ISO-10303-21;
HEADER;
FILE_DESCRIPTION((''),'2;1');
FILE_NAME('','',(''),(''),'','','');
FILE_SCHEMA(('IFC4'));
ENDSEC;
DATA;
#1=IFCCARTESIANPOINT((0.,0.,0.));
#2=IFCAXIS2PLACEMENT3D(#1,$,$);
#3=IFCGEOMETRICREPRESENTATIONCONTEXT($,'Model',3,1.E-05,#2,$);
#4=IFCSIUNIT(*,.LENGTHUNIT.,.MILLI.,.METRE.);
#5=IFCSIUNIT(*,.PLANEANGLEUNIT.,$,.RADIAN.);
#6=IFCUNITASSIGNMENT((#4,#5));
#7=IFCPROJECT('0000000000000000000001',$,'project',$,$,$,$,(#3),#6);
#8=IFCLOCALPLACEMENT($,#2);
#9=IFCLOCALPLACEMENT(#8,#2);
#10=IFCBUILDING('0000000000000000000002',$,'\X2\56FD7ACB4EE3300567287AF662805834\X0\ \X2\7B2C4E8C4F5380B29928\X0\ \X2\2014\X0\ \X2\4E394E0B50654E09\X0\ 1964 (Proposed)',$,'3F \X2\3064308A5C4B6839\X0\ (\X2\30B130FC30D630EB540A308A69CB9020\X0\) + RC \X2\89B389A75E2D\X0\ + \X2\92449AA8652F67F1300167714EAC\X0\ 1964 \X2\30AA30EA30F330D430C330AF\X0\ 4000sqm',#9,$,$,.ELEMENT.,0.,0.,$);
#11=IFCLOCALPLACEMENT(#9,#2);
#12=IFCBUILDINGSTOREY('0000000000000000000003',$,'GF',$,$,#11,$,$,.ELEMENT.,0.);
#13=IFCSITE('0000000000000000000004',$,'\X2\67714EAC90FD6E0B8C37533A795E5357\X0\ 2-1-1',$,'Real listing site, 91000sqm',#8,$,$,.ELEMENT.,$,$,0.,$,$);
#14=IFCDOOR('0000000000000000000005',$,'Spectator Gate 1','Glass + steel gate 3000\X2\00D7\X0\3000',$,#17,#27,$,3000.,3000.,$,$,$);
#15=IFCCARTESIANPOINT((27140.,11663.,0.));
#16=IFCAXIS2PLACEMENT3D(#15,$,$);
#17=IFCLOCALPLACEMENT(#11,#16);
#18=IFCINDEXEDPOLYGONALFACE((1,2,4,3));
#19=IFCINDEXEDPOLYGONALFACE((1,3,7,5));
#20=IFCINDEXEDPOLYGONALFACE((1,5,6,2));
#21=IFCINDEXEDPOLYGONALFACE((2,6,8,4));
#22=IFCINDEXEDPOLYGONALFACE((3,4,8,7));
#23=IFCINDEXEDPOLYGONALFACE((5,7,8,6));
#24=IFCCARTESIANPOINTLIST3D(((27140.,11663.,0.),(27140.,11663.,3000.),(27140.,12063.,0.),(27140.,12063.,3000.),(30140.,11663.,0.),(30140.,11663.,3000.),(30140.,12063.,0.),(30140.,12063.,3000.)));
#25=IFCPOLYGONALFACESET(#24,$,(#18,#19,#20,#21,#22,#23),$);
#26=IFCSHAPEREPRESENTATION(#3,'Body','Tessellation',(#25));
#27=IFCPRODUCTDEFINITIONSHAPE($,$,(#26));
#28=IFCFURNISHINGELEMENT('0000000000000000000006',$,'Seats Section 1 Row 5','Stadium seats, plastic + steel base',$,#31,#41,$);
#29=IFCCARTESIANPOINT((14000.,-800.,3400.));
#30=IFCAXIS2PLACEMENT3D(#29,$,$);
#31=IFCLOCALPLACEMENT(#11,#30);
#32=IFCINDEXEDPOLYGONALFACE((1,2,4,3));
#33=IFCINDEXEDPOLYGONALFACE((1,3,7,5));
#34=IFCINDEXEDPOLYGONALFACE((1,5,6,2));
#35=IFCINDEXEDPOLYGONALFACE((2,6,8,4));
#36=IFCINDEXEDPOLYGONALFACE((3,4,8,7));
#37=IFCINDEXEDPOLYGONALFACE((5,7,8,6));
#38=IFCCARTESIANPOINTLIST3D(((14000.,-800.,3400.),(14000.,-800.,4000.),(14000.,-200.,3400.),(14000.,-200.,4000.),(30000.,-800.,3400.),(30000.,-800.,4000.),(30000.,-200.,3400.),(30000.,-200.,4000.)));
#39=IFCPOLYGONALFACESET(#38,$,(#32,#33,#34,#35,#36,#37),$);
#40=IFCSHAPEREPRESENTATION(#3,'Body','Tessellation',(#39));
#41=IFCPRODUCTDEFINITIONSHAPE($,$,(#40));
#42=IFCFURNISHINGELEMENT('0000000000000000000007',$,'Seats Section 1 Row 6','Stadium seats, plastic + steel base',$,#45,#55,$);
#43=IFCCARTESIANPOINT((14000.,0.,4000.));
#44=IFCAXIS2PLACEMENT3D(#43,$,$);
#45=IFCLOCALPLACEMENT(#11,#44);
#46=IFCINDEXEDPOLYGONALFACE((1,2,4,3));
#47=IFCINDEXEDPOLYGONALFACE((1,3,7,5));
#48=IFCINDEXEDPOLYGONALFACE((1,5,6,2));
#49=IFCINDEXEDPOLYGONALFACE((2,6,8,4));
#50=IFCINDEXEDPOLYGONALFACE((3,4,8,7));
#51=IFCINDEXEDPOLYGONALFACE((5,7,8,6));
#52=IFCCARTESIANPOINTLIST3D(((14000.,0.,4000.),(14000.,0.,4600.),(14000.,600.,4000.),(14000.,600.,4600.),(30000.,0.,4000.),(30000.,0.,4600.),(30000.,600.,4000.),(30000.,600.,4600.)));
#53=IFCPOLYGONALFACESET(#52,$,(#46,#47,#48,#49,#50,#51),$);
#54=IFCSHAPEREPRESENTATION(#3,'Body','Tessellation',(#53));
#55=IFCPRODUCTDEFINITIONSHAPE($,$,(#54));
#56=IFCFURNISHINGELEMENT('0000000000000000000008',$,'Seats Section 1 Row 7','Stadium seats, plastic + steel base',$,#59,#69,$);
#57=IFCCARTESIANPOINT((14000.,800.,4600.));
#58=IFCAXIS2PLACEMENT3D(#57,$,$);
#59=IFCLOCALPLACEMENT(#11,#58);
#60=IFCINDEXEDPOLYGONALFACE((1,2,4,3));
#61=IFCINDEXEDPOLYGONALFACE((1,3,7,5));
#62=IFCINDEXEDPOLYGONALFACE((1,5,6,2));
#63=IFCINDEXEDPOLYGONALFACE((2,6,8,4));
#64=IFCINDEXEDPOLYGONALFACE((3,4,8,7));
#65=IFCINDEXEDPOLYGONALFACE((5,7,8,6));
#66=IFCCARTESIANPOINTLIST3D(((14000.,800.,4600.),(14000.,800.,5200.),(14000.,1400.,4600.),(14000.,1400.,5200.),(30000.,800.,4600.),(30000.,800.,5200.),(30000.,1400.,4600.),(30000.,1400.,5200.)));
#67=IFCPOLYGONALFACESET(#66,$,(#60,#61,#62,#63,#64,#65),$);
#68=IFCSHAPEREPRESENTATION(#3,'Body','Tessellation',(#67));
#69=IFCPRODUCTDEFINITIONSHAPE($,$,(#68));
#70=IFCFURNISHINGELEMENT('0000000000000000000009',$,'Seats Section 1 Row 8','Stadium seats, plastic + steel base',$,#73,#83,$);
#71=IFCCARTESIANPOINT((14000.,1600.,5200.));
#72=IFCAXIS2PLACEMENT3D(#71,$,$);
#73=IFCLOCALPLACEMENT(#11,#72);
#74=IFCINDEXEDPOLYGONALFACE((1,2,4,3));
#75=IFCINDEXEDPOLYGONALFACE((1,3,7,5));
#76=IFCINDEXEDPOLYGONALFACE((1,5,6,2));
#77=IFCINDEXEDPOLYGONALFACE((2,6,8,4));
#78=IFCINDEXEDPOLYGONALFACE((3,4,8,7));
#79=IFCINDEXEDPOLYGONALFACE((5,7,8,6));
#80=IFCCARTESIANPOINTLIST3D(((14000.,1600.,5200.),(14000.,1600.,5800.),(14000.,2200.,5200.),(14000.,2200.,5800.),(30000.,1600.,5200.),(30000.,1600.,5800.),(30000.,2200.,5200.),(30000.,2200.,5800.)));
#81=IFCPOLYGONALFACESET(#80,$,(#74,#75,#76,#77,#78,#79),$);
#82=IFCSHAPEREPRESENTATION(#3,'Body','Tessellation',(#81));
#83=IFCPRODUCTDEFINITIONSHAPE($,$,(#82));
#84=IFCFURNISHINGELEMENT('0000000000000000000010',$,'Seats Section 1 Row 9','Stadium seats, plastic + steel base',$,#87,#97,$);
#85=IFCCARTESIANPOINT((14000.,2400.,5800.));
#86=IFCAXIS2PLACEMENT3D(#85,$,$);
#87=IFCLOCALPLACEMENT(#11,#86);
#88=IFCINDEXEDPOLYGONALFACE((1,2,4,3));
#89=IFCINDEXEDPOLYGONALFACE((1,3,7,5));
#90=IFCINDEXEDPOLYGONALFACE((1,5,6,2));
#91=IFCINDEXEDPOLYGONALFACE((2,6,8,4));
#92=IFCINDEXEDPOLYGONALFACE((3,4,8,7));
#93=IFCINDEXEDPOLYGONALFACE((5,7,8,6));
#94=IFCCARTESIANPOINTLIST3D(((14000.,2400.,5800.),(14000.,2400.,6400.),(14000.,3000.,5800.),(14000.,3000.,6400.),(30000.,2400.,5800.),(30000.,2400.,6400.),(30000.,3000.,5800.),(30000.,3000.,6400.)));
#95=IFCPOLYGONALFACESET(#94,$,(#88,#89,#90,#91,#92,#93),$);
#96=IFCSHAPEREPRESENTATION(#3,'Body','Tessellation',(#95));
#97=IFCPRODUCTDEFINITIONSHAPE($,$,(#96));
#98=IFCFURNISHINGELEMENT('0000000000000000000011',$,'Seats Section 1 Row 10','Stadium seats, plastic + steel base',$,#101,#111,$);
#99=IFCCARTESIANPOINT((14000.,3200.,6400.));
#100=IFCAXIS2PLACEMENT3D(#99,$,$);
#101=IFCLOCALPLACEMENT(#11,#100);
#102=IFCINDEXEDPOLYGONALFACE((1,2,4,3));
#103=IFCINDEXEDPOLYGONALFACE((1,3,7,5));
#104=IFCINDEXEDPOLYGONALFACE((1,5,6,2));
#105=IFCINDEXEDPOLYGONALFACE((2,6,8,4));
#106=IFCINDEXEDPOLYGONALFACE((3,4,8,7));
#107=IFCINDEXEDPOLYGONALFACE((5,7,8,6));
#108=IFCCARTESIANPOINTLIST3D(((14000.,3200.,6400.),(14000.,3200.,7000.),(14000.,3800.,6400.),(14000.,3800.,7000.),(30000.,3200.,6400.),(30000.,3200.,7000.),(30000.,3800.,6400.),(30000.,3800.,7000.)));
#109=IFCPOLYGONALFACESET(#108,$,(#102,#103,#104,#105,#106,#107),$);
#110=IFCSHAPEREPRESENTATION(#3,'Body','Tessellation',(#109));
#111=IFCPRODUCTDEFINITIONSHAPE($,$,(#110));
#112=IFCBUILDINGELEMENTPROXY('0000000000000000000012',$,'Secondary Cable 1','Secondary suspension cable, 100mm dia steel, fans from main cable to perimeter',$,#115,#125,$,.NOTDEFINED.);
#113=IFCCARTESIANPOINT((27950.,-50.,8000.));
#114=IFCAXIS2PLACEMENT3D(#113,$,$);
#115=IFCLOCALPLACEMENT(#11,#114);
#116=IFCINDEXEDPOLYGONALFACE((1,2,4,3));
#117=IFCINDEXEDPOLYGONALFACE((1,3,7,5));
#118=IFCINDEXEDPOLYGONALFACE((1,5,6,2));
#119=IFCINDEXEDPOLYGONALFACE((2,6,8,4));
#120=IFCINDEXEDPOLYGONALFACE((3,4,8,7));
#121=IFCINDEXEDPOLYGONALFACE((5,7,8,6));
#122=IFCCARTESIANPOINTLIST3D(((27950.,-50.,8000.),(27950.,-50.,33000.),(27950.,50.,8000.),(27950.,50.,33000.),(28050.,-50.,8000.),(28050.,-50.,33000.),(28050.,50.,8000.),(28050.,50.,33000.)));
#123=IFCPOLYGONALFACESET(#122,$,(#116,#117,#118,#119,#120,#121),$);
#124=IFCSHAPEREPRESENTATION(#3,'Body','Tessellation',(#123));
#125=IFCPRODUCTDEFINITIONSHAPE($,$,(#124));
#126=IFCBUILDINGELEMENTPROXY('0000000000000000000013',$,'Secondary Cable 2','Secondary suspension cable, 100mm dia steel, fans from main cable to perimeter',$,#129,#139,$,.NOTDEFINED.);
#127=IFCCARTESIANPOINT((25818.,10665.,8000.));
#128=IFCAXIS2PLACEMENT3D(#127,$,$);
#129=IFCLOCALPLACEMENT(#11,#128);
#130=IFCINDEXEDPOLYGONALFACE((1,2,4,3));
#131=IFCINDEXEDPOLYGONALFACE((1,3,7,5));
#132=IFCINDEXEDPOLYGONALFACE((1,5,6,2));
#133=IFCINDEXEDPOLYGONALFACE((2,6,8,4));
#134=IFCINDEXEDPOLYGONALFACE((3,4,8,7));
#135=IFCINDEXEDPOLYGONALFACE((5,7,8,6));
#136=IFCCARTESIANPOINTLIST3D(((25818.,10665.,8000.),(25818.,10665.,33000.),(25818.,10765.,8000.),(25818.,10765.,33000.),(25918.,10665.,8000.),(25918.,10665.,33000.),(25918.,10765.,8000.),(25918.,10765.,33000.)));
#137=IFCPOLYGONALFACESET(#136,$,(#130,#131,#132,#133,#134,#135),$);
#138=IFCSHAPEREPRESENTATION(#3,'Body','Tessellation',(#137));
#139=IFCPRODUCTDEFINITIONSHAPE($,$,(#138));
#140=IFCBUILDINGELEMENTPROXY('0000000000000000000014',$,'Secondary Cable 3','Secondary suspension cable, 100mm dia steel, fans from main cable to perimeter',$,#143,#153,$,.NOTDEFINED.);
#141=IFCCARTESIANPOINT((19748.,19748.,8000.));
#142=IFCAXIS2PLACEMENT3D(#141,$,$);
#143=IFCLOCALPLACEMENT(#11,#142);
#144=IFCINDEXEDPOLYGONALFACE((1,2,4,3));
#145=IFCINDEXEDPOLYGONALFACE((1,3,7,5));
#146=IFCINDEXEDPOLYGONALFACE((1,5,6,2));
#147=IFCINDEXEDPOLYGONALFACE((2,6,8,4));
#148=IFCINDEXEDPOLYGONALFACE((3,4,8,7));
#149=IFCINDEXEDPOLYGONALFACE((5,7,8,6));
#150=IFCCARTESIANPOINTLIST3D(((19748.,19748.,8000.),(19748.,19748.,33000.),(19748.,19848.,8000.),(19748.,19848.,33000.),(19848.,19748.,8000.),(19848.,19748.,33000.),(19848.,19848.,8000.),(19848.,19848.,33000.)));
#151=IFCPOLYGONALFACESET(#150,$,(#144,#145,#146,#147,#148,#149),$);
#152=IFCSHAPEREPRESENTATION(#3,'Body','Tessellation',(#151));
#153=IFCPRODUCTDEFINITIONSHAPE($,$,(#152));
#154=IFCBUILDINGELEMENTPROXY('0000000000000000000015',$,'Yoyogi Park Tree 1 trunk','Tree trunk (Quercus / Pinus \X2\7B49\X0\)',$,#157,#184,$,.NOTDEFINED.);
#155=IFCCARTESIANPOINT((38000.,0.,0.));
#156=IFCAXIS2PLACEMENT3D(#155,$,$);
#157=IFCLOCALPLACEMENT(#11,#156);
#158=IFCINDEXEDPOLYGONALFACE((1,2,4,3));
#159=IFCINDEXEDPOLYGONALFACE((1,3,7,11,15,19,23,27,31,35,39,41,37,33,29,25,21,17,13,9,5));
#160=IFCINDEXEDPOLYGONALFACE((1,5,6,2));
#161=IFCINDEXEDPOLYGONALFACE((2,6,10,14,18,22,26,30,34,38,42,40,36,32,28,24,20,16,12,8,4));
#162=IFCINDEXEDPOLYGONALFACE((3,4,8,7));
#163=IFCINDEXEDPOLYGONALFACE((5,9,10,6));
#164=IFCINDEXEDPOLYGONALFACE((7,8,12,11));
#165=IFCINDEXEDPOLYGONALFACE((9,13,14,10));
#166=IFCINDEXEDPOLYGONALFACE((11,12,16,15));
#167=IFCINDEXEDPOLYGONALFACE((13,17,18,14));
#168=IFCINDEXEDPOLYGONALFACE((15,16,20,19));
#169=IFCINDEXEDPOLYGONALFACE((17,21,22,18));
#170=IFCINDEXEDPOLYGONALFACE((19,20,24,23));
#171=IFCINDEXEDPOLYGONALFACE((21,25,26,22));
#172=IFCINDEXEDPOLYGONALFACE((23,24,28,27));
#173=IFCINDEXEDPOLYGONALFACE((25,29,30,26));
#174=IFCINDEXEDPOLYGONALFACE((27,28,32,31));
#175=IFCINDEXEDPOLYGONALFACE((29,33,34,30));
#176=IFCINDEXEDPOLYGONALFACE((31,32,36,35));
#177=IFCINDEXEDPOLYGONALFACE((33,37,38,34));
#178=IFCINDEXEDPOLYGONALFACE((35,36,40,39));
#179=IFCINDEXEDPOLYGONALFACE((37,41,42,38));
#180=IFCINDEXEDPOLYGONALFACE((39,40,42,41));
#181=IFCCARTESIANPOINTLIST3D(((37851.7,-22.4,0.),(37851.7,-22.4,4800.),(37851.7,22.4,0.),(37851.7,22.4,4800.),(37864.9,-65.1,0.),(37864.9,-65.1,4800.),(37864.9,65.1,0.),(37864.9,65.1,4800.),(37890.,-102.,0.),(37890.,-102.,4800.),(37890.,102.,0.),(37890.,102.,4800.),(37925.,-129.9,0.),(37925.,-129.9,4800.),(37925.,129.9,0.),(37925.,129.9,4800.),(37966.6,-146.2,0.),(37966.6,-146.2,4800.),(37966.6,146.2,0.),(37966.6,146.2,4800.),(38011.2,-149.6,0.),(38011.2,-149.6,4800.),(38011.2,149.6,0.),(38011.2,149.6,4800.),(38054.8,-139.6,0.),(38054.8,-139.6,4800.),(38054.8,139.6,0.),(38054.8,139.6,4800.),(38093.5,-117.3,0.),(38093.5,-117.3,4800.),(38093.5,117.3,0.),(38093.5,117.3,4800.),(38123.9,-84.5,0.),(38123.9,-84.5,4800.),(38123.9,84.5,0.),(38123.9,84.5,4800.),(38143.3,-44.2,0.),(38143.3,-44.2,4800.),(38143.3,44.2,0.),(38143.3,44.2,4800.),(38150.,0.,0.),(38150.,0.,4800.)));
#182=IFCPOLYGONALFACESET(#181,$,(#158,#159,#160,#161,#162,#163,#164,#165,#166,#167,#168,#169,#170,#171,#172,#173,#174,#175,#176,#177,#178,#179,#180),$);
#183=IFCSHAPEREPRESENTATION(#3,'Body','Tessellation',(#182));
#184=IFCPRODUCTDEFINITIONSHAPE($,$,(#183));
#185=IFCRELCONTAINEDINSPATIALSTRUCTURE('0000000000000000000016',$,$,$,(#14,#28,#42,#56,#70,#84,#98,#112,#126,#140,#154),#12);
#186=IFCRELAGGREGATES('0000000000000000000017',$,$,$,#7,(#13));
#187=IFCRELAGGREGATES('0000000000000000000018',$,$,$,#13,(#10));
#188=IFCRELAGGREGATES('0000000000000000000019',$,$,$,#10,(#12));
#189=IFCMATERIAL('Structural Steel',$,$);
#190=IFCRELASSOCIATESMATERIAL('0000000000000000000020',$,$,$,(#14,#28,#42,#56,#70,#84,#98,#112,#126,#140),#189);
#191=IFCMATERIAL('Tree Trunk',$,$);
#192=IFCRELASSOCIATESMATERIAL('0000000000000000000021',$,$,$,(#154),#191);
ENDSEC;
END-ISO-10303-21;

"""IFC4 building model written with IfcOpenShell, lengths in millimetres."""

from ifc_helpers import new_model, si_unit, frame, frame_2d, origin, origin_2d, place, context, project, spatial, rectangle, circle, extrude, material, element, save


model = new_model("IFC4")

# Units and contexts
model_context = context("Model", 3, precision=1e-05, world=origin())
ifc_project = project(units=[si_unit("LENGTHUNIT", "METRE", prefix="MILLI"), si_unit("PLANEANGLEUNIT", "RADIAN")], contexts=[model_context])

# Site, building, storey
site_placement = place(None, origin())
site = spatial("IfcSite", under=ifc_project, at=site_placement, Name="東京都渋谷区神南 2-1-1", ObjectType="Real listing site, 91000sqm", CompositionType="ELEMENT", RefElevation=0.0)
building_placement = place(site_placement, origin())
building = spatial("IfcBuilding", under=site, at=building_placement, Name="国立代々木競技場 第二体育館 — 丹下健三 1964 (Proposed)", ObjectType="3F つり屋根 (ケーブル吊り構造) + RC 観覧席 + 鉄骨支柱、東京 1964 オリンピック 4000sqm", CompositionType="ELEMENT", ElevationOfRefHeight=0.0, ElevationOfTerrain=0.0)
storey_placement = place(building_placement, origin())
storey = spatial("IfcBuildingStorey", under=building, at=storey_placement, Name="GF", CompositionType="ELEMENT", Elevation=0.0)

# Door
ifc_material_1 = material(Name="Structural Steel")
door_placement = place(storey_placement, frame((27140.0, 11663.0, 0.0)))
element("IfcDoor", 1, at=door_placement, inside=storey, material=ifc_material_1, Name="Spectator Gate 1", Description="Glass + steel gate 3000×3000", OverallHeight=3000.0, OverallWidth=3000.0, context=model_context, shape_type="SweptSolid", body=[
    extrude(rectangle(XDim=3000.0, YDim=400.0, at=frame_2d((1500.0, 200.0))), frame((27140.0, 11663.0, 0.0)), (0.0, 0.0, 1.0), 3000.0),
])

# Furnishing elements
furnishing_1_placement = place(storey_placement, frame((14000.0, -800.0, 3400.0)))
element("IfcFurnishingElement", 2, at=furnishing_1_placement, inside=storey, material=ifc_material_1, Name="Seats Section 1 Row 5", Description="Stadium seats, plastic + steel base", context=model_context, shape_type="SweptSolid", body=[
    extrude(rectangle(XDim=16000.0, YDim=600.0, at=frame_2d((8000.0, 300.0))), frame((14000.0, -800.0, 3400.0)), (0.0, 0.0, 1.0), 600.0),
])
furnishing_2_placement = place(storey_placement, frame((14000.0, 0.0, 4000.0)))
element("IfcFurnishingElement", 3, at=furnishing_2_placement, inside=storey, material=ifc_material_1, Name="Seats Section 1 Row 6", Description="Stadium seats, plastic + steel base", context=model_context, shape_type="SweptSolid", body=[
    extrude(rectangle(XDim=16000.0, YDim=600.0, at=frame_2d((8000.0, 300.0))), frame((14000.0, 0.0, 4000.0)), (0.0, 0.0, 1.0), 600.0),
])
furnishing_3_placement = place(storey_placement, frame((14000.0, 800.0, 4600.0)))
element("IfcFurnishingElement", 4, at=furnishing_3_placement, inside=storey, material=ifc_material_1, Name="Seats Section 1 Row 7", Description="Stadium seats, plastic + steel base", context=model_context, shape_type="SweptSolid", body=[
    extrude(rectangle(XDim=16000.0, YDim=600.0, at=frame_2d((8000.0, 300.0))), frame((14000.0, 800.0, 4600.0)), (0.0, 0.0, 1.0), 600.0),
])
furnishing_4_placement = place(storey_placement, frame((14000.0, 1600.0, 5200.0)))
element("IfcFurnishingElement", 5, at=furnishing_4_placement, inside=storey, material=ifc_material_1, Name="Seats Section 1 Row 8", Description="Stadium seats, plastic + steel base", context=model_context, shape_type="SweptSolid", body=[
    extrude(rectangle(XDim=16000.0, YDim=600.0, at=frame_2d((8000.0, 300.0))), frame((14000.0, 1600.0, 5200.0)), (0.0, 0.0, 1.0), 600.0),
])
furnishing_5_placement = place(storey_placement, frame((14000.0, 2400.0, 5800.0)))
element("IfcFurnishingElement", 6, at=furnishing_5_placement, inside=storey, material=ifc_material_1, Name="Seats Section 1 Row 9", Description="Stadium seats, plastic + steel base", context=model_context, shape_type="SweptSolid", body=[
    extrude(rectangle(XDim=16000.0, YDim=600.0, at=frame_2d((8000.0, 300.0))), frame((14000.0, 2400.0, 5800.0)), (0.0, 0.0, 1.0), 600.0),
])
furnishing_6_placement = place(storey_placement, frame((14000.0, 3200.0, 6400.0)))
element("IfcFurnishingElement", 7, at=furnishing_6_placement, inside=storey, material=ifc_material_1, Name="Seats Section 1 Row 10", Description="Stadium seats, plastic + steel base", context=model_context, shape_type="SweptSolid", body=[
    extrude(rectangle(XDim=16000.0, YDim=600.0, at=frame_2d((8000.0, 300.0))), frame((14000.0, 3200.0, 6400.0)), (0.0, 0.0, 1.0), 600.0),
])

# Building element proxies
proxy_1_placement = place(storey_placement, frame((27950.0, -50.0, 8000.0)))
element("IfcBuildingElementProxy", 8, at=proxy_1_placement, inside=storey, material=ifc_material_1, Name="Secondary Cable 1", Description="Secondary suspension cable, 100mm dia steel, fans from main cable to perimeter", PredefinedType="NOTDEFINED", context=model_context, shape_type="SweptSolid", body=[
    extrude(rectangle(XDim=100.0, YDim=100.0, at=frame_2d((50.0, 50.0))), frame((27950.0, -50.0, 8000.0)), (0.0, 0.0, 1.0), 25000.0),
])
proxy_2_placement = place(storey_placement, frame((25818.0, 10665.0, 8000.0)))
element("IfcBuildingElementProxy", 9, at=proxy_2_placement, inside=storey, material=ifc_material_1, Name="Secondary Cable 2", Description="Secondary suspension cable, 100mm dia steel, fans from main cable to perimeter", PredefinedType="NOTDEFINED", context=model_context, shape_type="SweptSolid", body=[
    extrude(rectangle(XDim=100.0, YDim=100.0, at=frame_2d((50.0, 50.0))), frame((25818.0, 10665.0, 8000.0)), (0.0, 0.0, 1.0), 25000.0),
])
proxy_3_placement = place(storey_placement, frame((19748.0, 19748.0, 8000.0)))
element("IfcBuildingElementProxy", 10, at=proxy_3_placement, inside=storey, material=ifc_material_1, Name="Secondary Cable 3", Description="Secondary suspension cable, 100mm dia steel, fans from main cable to perimeter", PredefinedType="NOTDEFINED", context=model_context, shape_type="SweptSolid", body=[
    extrude(rectangle(XDim=100.0, YDim=100.0, at=frame_2d((50.0, 50.0))), frame((19748.0, 19748.0, 8000.0)), (0.0, 0.0, 1.0), 25000.0),
])
ifc_material_2 = material(Name="Tree Trunk")
proxy_4_placement = place(storey_placement, frame((38000.0, 0.0, 0.0)))
element("IfcBuildingElementProxy", 11, at=proxy_4_placement, inside=storey, material=ifc_material_2, Name="Yoyogi Park Tree 1 trunk", Description="Tree trunk (Quercus / Pinus 等)", PredefinedType="NOTDEFINED", context=model_context, shape_type="SweptSolid", body=[
    extrude(circle(Radius=150.0, at=origin_2d()), frame((38000.0, 0.0, 0.0)), (0.0, 0.0, 1.0), 4800.0),
])

save(model, "model.ifc")
